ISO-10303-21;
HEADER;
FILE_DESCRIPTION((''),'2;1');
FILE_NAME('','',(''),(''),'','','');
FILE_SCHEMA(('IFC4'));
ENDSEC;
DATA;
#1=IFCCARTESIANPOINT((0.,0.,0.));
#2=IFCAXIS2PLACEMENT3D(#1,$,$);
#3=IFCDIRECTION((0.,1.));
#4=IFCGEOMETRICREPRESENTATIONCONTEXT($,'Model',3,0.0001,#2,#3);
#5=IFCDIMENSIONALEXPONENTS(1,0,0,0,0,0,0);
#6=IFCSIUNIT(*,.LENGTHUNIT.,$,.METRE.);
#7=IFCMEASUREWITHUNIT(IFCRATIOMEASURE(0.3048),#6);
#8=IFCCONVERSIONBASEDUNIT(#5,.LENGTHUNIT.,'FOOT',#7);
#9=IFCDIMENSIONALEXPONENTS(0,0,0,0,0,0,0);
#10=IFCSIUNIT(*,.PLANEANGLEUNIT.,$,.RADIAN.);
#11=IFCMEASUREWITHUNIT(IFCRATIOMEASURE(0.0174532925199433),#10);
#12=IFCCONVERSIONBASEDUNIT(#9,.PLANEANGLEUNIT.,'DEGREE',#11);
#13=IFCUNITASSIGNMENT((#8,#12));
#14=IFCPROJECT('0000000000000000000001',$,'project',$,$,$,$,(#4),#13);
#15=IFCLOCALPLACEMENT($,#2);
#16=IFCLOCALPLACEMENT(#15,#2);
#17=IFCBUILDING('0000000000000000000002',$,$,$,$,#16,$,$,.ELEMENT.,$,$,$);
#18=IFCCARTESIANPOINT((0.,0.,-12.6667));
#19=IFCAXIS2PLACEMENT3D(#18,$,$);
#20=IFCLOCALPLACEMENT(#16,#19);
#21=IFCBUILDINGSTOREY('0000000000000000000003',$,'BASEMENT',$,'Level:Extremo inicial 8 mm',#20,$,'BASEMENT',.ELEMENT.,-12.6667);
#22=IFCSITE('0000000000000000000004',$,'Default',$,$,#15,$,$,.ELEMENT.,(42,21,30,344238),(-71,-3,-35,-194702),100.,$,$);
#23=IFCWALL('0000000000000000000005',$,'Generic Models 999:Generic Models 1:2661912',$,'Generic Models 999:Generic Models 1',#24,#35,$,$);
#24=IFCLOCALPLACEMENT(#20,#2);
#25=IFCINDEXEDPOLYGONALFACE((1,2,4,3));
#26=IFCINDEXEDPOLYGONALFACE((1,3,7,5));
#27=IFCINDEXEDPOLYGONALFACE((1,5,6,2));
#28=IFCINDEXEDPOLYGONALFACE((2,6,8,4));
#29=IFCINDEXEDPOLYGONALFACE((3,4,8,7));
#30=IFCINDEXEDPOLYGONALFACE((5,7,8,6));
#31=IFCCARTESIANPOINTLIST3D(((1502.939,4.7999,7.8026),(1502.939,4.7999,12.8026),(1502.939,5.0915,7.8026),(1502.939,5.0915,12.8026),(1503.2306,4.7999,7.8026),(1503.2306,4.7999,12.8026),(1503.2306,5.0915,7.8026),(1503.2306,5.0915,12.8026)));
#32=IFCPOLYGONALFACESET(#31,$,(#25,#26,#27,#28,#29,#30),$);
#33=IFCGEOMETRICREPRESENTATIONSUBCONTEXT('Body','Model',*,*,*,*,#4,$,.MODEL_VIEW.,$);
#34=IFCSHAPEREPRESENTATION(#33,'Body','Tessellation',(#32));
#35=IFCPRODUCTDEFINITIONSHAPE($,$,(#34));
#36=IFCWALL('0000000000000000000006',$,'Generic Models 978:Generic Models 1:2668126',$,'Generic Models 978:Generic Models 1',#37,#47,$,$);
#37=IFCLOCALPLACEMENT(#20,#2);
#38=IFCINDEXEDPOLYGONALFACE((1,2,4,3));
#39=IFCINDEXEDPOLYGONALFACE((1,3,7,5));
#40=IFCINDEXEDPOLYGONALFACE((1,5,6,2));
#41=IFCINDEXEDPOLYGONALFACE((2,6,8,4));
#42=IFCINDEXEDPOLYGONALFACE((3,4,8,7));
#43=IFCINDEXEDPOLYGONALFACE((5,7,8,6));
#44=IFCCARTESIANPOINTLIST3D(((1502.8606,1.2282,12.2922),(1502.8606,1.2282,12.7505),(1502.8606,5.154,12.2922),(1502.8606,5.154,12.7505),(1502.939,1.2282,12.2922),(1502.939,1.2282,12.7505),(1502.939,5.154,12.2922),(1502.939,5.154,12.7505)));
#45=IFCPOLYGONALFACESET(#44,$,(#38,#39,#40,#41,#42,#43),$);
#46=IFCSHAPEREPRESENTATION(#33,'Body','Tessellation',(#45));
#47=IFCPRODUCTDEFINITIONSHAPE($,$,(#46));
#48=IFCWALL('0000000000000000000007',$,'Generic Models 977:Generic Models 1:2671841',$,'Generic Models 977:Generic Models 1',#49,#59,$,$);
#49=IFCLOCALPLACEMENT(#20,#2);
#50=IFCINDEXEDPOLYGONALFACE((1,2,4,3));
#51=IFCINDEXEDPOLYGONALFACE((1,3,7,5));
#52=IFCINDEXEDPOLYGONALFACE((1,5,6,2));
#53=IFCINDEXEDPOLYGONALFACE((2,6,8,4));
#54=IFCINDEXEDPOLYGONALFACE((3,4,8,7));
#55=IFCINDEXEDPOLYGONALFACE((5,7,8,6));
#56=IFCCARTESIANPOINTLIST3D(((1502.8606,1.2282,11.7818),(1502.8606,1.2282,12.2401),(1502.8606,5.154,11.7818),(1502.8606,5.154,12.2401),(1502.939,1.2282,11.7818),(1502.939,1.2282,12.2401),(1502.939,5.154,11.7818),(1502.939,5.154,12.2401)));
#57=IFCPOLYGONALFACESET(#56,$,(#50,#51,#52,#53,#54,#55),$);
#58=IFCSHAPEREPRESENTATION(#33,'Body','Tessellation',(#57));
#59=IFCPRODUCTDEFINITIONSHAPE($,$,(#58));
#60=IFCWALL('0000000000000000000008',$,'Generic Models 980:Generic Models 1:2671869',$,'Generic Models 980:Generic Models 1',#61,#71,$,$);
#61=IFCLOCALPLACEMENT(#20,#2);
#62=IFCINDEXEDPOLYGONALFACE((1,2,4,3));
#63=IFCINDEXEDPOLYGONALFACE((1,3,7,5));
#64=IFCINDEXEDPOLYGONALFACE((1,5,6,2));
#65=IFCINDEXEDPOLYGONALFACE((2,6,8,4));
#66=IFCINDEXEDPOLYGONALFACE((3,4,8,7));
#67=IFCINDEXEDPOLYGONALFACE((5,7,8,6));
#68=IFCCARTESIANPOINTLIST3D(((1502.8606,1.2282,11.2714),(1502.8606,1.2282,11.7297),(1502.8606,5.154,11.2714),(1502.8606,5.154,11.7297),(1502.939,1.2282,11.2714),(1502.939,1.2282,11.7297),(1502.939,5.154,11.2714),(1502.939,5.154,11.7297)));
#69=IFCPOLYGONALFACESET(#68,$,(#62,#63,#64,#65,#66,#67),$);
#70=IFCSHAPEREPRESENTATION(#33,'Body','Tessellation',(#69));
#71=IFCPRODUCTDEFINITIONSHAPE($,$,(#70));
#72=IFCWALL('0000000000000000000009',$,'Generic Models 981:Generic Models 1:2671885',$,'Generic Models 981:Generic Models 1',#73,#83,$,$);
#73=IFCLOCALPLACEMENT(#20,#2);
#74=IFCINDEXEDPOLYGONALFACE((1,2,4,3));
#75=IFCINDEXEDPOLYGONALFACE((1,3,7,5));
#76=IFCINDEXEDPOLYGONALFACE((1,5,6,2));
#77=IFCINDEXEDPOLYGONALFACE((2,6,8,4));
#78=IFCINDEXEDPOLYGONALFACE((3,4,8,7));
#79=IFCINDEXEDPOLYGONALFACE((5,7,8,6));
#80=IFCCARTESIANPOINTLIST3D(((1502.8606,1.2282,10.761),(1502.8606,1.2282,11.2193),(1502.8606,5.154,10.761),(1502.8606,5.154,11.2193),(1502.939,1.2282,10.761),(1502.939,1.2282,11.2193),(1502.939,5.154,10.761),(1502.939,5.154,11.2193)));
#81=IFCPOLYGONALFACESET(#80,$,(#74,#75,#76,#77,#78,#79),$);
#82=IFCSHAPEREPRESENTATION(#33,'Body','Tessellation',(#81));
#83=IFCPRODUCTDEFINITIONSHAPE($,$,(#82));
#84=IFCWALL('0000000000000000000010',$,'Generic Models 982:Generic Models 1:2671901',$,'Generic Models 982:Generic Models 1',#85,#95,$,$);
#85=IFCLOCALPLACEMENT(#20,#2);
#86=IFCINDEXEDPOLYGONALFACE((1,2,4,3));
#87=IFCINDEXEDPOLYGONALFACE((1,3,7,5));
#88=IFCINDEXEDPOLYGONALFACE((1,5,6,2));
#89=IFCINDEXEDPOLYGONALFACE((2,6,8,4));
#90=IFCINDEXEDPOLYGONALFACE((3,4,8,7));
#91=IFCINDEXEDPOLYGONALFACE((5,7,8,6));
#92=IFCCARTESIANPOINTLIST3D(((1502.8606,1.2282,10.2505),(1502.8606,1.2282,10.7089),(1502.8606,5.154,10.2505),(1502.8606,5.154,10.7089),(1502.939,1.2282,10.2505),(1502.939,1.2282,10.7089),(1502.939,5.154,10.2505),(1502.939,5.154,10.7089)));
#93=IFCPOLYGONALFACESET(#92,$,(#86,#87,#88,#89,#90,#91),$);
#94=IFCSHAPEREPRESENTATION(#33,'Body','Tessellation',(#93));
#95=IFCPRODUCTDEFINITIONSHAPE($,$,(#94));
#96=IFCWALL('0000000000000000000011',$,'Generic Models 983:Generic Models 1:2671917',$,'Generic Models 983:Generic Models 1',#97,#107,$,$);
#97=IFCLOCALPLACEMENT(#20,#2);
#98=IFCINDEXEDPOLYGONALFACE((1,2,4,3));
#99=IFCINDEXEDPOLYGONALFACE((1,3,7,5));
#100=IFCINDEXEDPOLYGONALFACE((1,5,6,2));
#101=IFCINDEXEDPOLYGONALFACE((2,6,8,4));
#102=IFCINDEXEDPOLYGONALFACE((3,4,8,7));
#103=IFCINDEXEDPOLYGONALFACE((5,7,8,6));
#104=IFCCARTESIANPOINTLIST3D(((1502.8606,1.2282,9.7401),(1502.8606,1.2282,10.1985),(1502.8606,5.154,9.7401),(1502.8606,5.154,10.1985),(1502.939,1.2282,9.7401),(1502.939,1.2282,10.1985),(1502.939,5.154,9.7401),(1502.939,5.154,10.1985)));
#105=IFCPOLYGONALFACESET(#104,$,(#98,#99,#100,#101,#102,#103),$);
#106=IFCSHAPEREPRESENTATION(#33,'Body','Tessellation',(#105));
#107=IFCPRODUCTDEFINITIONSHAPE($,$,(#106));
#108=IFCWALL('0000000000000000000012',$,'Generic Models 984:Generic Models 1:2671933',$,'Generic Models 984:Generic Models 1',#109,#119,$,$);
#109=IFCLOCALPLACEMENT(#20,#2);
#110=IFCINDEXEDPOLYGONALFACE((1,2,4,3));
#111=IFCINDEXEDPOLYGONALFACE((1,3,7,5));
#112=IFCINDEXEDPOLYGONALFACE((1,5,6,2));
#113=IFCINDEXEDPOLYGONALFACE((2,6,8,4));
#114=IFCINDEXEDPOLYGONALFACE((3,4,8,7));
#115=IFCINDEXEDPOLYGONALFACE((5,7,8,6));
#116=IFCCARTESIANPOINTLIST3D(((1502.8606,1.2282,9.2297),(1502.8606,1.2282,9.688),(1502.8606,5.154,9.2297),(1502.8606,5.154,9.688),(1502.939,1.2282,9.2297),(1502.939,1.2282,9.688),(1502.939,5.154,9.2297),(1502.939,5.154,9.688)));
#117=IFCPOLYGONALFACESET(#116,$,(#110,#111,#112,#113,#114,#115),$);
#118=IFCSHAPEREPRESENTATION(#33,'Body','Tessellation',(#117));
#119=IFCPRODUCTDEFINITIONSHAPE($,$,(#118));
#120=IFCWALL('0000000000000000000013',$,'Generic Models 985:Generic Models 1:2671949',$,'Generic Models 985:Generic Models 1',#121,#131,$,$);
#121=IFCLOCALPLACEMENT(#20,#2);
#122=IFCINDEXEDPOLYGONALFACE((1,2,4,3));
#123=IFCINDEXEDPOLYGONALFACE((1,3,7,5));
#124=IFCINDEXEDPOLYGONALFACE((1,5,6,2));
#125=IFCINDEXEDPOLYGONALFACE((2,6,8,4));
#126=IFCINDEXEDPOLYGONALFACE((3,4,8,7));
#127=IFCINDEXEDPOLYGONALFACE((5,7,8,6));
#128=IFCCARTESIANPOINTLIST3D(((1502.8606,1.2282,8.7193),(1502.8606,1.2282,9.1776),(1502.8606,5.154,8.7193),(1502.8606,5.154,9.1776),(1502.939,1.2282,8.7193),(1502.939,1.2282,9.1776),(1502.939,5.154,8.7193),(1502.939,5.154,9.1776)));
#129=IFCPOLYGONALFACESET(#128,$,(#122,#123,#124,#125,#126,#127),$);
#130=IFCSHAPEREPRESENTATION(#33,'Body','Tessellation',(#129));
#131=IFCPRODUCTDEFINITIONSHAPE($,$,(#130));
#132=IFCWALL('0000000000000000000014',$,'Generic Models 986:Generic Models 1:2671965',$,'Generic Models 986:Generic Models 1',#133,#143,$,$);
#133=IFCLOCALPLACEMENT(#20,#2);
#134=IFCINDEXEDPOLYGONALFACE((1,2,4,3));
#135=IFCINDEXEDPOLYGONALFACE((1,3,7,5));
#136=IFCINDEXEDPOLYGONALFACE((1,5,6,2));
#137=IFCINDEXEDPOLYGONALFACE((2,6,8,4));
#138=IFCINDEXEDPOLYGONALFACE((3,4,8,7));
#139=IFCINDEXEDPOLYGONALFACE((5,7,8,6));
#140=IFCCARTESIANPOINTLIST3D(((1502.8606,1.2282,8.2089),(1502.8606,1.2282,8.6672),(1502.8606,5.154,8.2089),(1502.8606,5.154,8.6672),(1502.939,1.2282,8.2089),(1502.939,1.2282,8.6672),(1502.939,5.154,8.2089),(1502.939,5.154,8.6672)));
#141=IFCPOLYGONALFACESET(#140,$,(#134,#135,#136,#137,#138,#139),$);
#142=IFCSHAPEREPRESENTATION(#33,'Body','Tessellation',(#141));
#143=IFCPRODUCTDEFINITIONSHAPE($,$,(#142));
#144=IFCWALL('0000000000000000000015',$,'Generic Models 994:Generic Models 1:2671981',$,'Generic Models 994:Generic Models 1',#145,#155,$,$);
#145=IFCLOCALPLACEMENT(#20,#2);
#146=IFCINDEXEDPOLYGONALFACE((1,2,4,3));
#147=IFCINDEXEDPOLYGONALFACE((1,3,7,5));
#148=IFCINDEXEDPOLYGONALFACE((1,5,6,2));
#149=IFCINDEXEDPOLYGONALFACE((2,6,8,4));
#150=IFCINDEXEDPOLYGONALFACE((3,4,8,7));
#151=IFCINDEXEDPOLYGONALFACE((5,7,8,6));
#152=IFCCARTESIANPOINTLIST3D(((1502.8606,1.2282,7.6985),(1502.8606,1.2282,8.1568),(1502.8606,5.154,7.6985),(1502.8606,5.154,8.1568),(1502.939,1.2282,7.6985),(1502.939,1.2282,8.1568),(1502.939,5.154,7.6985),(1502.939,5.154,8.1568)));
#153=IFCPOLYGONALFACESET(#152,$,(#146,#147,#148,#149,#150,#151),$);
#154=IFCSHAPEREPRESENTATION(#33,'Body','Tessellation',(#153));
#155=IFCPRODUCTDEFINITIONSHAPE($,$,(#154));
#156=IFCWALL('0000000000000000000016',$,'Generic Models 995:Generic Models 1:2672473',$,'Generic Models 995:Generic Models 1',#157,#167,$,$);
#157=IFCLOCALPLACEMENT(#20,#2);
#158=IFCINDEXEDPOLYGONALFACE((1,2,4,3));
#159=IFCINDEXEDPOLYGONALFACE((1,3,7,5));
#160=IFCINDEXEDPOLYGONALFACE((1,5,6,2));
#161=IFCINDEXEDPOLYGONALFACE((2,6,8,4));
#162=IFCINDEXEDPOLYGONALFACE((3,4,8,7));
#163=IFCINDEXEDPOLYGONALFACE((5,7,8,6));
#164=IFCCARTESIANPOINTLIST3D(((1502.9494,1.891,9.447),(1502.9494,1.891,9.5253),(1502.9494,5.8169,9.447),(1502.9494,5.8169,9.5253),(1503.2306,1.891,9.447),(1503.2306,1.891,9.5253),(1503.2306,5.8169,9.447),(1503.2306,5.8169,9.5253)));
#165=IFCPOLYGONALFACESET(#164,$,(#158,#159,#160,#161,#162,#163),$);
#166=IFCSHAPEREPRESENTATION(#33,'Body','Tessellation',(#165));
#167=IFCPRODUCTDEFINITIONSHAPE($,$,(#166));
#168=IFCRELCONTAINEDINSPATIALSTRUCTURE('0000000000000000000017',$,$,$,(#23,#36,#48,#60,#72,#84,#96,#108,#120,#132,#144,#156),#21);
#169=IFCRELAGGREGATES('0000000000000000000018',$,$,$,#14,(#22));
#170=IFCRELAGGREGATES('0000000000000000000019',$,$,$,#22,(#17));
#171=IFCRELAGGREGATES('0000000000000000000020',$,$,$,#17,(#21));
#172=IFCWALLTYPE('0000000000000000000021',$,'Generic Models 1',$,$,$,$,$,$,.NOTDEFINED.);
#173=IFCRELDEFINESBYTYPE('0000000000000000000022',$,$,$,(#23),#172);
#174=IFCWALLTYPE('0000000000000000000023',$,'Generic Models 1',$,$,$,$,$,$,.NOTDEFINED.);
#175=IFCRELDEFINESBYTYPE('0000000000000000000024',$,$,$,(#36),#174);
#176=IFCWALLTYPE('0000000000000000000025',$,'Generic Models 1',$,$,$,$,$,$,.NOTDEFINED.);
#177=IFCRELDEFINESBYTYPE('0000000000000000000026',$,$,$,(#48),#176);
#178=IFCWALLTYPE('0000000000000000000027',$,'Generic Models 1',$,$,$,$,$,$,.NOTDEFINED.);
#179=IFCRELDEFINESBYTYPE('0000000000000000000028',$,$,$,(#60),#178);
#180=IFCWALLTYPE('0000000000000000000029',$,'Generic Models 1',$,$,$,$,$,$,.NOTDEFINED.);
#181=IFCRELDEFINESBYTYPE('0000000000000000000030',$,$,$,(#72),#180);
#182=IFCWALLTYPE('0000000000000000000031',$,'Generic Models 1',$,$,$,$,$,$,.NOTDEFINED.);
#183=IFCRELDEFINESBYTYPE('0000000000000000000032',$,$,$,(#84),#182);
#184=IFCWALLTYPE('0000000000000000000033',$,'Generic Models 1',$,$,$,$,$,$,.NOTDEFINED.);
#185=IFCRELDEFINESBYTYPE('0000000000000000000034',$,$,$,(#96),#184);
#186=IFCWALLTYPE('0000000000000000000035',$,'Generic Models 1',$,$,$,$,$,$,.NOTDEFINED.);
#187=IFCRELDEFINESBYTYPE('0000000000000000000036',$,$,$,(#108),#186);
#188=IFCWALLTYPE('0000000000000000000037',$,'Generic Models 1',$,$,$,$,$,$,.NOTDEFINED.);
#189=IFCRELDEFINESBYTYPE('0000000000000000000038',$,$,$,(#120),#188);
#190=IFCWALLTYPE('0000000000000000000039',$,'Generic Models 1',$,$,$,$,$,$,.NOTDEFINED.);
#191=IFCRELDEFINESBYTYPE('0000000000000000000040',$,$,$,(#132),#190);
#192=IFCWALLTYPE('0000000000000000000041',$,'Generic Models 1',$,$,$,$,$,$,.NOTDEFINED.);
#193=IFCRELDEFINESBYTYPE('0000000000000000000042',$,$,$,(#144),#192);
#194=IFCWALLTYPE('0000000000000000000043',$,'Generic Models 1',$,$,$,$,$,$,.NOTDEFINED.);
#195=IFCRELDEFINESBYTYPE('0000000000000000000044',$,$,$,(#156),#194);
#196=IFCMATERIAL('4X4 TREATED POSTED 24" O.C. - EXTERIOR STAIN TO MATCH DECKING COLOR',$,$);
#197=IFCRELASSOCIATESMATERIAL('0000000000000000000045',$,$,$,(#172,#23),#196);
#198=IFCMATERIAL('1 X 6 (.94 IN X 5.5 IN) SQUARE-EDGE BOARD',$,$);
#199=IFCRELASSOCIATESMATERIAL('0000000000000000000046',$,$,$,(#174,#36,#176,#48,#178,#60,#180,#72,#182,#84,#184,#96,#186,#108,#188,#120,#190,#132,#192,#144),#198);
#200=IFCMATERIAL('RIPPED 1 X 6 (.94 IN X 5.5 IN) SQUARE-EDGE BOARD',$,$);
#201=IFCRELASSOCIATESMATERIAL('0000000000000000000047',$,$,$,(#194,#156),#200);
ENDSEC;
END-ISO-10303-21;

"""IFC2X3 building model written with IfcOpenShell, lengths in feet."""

from ifc_helpers import new_model, entity, si_unit, converted_unit, direction, frame, frame_2d, origin, origin_2d_with_axis, place, context, subcontext, project, spatial, rectangle, extrude, material, type_object, element, save


model = new_model("IFC2X3")

# Units and contexts
model_context = context("Model", 3, precision=0.0001, world=origin(), true_north=direction((0.0, 1.0)))
body_context = subcontext(model_context, "Body", "Model", "MODEL_VIEW")
ifc_project = project(units=[converted_unit("LENGTHUNIT", "FOOT", entity("IfcRatioMeasure", 0.3048), si_unit("LENGTHUNIT", "METRE"), dimensions=[1, 0, 0, 0, 0, 0, 0]), converted_unit("PLANEANGLEUNIT", "DEGREE", entity("IfcRatioMeasure", 0.0174532925199433), si_unit("PLANEANGLEUNIT", "RADIAN"), dimensions=[0, 0, 0, 0, 0, 0, 0])], contexts=[model_context])

# Site, building, storey
site_placement = place(None, origin())
site = spatial("IfcSite", under=ifc_project, at=site_placement, Name="Default", CompositionType="ELEMENT", RefLatitude=(42, 21, 30, 344238), RefLongitude=(-71, -3, -35, -194702), RefElevation=100.0)
building_placement = place(site_placement, origin())
building = spatial("IfcBuilding", under=site, at=building_placement, CompositionType="ELEMENT")
storey_placement = place(building_placement, frame((0.0, 0.0, -12.6667)))
storey = spatial("IfcBuildingStorey", under=building, at=storey_placement, Name="BASEMENT", ObjectType="Level:Extremo inicial 8 mm", LongName="BASEMENT", CompositionType="ELEMENT", Elevation=-12.6667)

# Walls
ifc_material_1 = material(Name="4X4 TREATED POSTED 24\" O.C. - EXTERIOR STAIN TO MATCH DECKING COLOR")
wall_type_1 = type_object("IfcWallType", Name="Generic Models 1", PredefinedType="NOTDEFINED", material=ifc_material_1)
wall_1_placement = place(storey_placement, frame((1502.939, 4.7999, 7.8026)))
element("IfcWall", 1, at=wall_1_placement, inside=storey, type_object=wall_type_1, material=ifc_material_1, Name="Generic Models 999:Generic Models 1:2661912", ObjectType="Generic Models 999:Generic Models 1", context=body_context, shape_type="SweptSolid", body=[
    extrude(rectangle(XDim=0.2917, YDim=0.2917, at=frame_2d((0.0, 0.0), x_axis=(1.0, 0.0))), frame((0.1458, 0.1458, 0.0), z_axis=(0.0, 0.0, 1.0), x_axis=(0.0, 1.0, 0.0)), (0.0, 0.0, 1.0), 5.0),
])
ifc_material_2 = material(Name="1 X 6 (.94 IN X 5.5 IN) SQUARE-EDGE BOARD")
wall_type_2 = type_object("IfcWallType", Name="Generic Models 1", PredefinedType="NOTDEFINED", material=ifc_material_2)
wall_2_placement = place(storey_placement, frame((1502.8606, 1.2282, 12.2922), z_axis=(0.0, 0.0, 1.0), x_axis=(0.0, 1.0, 0.0)))
element("IfcWall", 2, at=wall_2_placement, inside=storey, type_object=wall_type_2, material=ifc_material_2, Name="Generic Models 978:Generic Models 1:2668126", ObjectType="Generic Models 978:Generic Models 1", context=body_context, shape_type="SweptSolid", body=[
    extrude(rectangle(XDim=3.9258, YDim=0.0783, at=frame_2d((0.0, 0.0), x_axis=(1.0, 0.0))), frame((1.9629, -0.0392, 0.0)), (0.0, 0.0, 1.0), 0.4583),
])
wall_type_3 = type_object("IfcWallType", Name="Generic Models 1", PredefinedType="NOTDEFINED", material=ifc_material_2)
wall_3_placement = place(storey_placement, frame((1502.8606, 1.2282, 11.7818), z_axis=(0.0, 0.0, 1.0), x_axis=(0.0, 1.0, 0.0)))
element("IfcWall", 3, at=wall_3_placement, inside=storey, type_object=wall_type_3, material=ifc_material_2, Name="Generic Models 977:Generic Models 1:2671841", ObjectType="Generic Models 977:Generic Models 1", context=body_context, shape_type="SweptSolid", body=[
    extrude(rectangle(XDim=3.9258, YDim=0.0783, at=frame_2d((0.0, 0.0), x_axis=(1.0, 0.0))), frame((1.9629, -0.0392, 0.0)), (0.0, 0.0, 1.0), 0.4583),
])
wall_type_4 = type_object("IfcWallType", Name="Generic Models 1", PredefinedType="NOTDEFINED", material=ifc_material_2)
wall_4_placement = place(storey_placement, frame((1502.8606, 1.2282, 11.2714), z_axis=(0.0, 0.0, 1.0), x_axis=(0.0, 1.0, 0.0)))
element("IfcWall", 4, at=wall_4_placement, inside=storey, type_object=wall_type_4, material=ifc_material_2, Name="Generic Models 980:Generic Models 1:2671869", ObjectType="Generic Models 980:Generic Models 1", context=body_context, shape_type="SweptSolid", body=[
    extrude(rectangle(XDim=3.9258, YDim=0.0783, at=frame_2d((0.0, 0.0), x_axis=(1.0, 0.0))), frame((1.9629, -0.0392, 0.0)), (0.0, 0.0, 1.0), 0.4583),
])
wall_type_5 = type_object("IfcWallType", Name="Generic Models 1", PredefinedType="NOTDEFINED", material=ifc_material_2)
wall_5_placement = place(storey_placement, frame((1502.8606, 1.2282, 10.761), z_axis=(0.0, 0.0, 1.0), x_axis=(0.0, 1.0, 0.0)))
element("IfcWall", 5, at=wall_5_placement, inside=storey, type_object=wall_type_5, material=ifc_material_2, Name="Generic Models 981:Generic Models 1:2671885", ObjectType="Generic Models 981:Generic Models 1", context=body_context, shape_type="SweptSolid", body=[
    extrude(rectangle(XDim=3.9258, YDim=0.0783, at=frame_2d((0.0, 0.0), x_axis=(1.0, 0.0))), frame((1.9629, -0.0392, 0.0)), (0.0, 0.0, 1.0), 0.4583),
])
wall_type_6 = type_object("IfcWallType", Name="Generic Models 1", PredefinedType="NOTDEFINED", material=ifc_material_2)
wall_6_placement = place(storey_placement, frame((1502.8606, 1.2282, 10.2505), z_axis=(0.0, 0.0, 1.0), x_axis=(0.0, 1.0, 0.0)))
element("IfcWall", 6, at=wall_6_placement, inside=storey, type_object=wall_type_6, material=ifc_material_2, Name="Generic Models 982:Generic Models 1:2671901", ObjectType="Generic Models 982:Generic Models 1", context=body_context, shape_type="SweptSolid", body=[
    extrude(rectangle(XDim=3.9258, YDim=0.0783, at=frame_2d((0.0, 0.0), x_axis=(1.0, 0.0))), frame((1.9629, -0.0392, 0.0)), (0.0, 0.0, 1.0), 0.4583),
])
wall_type_7 = type_object("IfcWallType", Name="Generic Models 1", PredefinedType="NOTDEFINED", material=ifc_material_2)
wall_7_placement = place(storey_placement, frame((1502.8606, 1.2282, 9.7401), z_axis=(0.0, 0.0, 1.0), x_axis=(0.0, 1.0, 0.0)))
element("IfcWall", 7, at=wall_7_placement, inside=storey, type_object=wall_type_7, material=ifc_material_2, Name="Generic Models 983:Generic Models 1:2671917", ObjectType="Generic Models 983:Generic Models 1", context=body_context, shape_type="SweptSolid", body=[
    extrude(rectangle(XDim=3.9258, YDim=0.0783, at=frame_2d((0.0, 0.0), x_axis=(1.0, 0.0))), frame((1.9629, -0.0392, 0.0)), (0.0, 0.0, 1.0), 0.4583),
])
wall_type_8 = type_object("IfcWallType", Name="Generic Models 1", PredefinedType="NOTDEFINED", material=ifc_material_2)
wall_8_placement = place(storey_placement, frame((1502.8606, 1.2282, 9.2297), z_axis=(0.0, 0.0, 1.0), x_axis=(0.0, 1.0, 0.0)))
element("IfcWall", 8, at=wall_8_placement, inside=storey, type_object=wall_type_8, material=ifc_material_2, Name="Generic Models 984:Generic Models 1:2671933", ObjectType="Generic Models 984:Generic Models 1", context=body_context, shape_type="SweptSolid", body=[
    extrude(rectangle(XDim=3.9258, YDim=0.0783, at=frame_2d((0.0, 0.0), x_axis=(1.0, 0.0))), frame((1.9629, -0.0392, 0.0)), (0.0, 0.0, 1.0), 0.4583),
])
wall_type_9 = type_object("IfcWallType", Name="Generic Models 1", PredefinedType="NOTDEFINED", material=ifc_material_2)
wall_9_placement = place(storey_placement, frame((1502.8606, 1.2282, 8.7193), z_axis=(0.0, 0.0, 1.0), x_axis=(0.0, 1.0, 0.0)))
element("IfcWall", 9, at=wall_9_placement, inside=storey, type_object=wall_type_9, material=ifc_material_2, Name="Generic Models 985:Generic Models 1:2671949", ObjectType="Generic Models 985:Generic Models 1", context=body_context, shape_type="SweptSolid", body=[
    extrude(rectangle(XDim=3.9258, YDim=0.0783, at=frame_2d((0.0, 0.0), x_axis=(1.0, 0.0))), frame((1.9629, -0.0392, 0.0)), (0.0, 0.0, 1.0), 0.4583),
])
wall_type_10 = type_object("IfcWallType", Name="Generic Models 1", PredefinedType="NOTDEFINED", material=ifc_material_2)
wall_10_placement = place(storey_placement, frame((1502.8606, 1.2282, 8.2089), z_axis=(0.0, 0.0, 1.0), x_axis=(0.0, 1.0, 0.0)))
element("IfcWall", 10, at=wall_10_placement, inside=storey, type_object=wall_type_10, material=ifc_material_2, Name="Generic Models 986:Generic Models 1:2671965", ObjectType="Generic Models 986:Generic Models 1", context=body_context, shape_type="SweptSolid", body=[
    extrude(rectangle(XDim=3.9258, YDim=0.0783, at=frame_2d((0.0, 0.0), x_axis=(1.0, 0.0))), frame((1.9629, -0.0392, 0.0)), (0.0, 0.0, 1.0), 0.4583),
])
wall_type_11 = type_object("IfcWallType", Name="Generic Models 1", PredefinedType="NOTDEFINED", material=ifc_material_2)
wall_11_placement = place(storey_placement, frame((1502.8606, 1.2282, 7.6985), z_axis=(0.0, 0.0, 1.0), x_axis=(0.0, 1.0, 0.0)))
element("IfcWall", 11, at=wall_11_placement, inside=storey, type_object=wall_type_11, material=ifc_material_2, Name="Generic Models 994:Generic Models 1:2671981", ObjectType="Generic Models 994:Generic Models 1", context=body_context, shape_type="SweptSolid", body=[
    extrude(rectangle(XDim=3.9258, YDim=0.0783, at=frame_2d((0.0, 0.0), x_axis=(1.0, 0.0))), frame((1.9629, -0.0392, 0.0)), (0.0, 0.0, 1.0), 0.4583),
])
ifc_material_3 = material(Name="RIPPED 1 X 6 (.94 IN X 5.5 IN) SQUARE-EDGE BOARD")
wall_type_12 = type_object("IfcWallType", Name="Generic Models 1", PredefinedType="NOTDEFINED", material=ifc_material_3)
wall_12_placement = place(storey_placement, frame((1502.9494, 1.891, 9.447), z_axis=(0.0, 0.0, 1.0), x_axis=(0.0, 1.0, 0.0)))
element("IfcWall", 12, at=wall_12_placement, inside=storey, type_object=wall_type_12, material=ifc_material_3, Name="Generic Models 995:Generic Models 1:2672473", ObjectType="Generic Models 995:Generic Models 1", context=body_context, shape_type="SweptSolid", body=[
    extrude(rectangle(XDim=3.9258, YDim=0.2812, at=origin_2d_with_axis()), frame((1.9629, -0.1406, 0.0)), (0.0, 0.0, 1.0), 0.0783),
])

save(model, "model.ifc")
